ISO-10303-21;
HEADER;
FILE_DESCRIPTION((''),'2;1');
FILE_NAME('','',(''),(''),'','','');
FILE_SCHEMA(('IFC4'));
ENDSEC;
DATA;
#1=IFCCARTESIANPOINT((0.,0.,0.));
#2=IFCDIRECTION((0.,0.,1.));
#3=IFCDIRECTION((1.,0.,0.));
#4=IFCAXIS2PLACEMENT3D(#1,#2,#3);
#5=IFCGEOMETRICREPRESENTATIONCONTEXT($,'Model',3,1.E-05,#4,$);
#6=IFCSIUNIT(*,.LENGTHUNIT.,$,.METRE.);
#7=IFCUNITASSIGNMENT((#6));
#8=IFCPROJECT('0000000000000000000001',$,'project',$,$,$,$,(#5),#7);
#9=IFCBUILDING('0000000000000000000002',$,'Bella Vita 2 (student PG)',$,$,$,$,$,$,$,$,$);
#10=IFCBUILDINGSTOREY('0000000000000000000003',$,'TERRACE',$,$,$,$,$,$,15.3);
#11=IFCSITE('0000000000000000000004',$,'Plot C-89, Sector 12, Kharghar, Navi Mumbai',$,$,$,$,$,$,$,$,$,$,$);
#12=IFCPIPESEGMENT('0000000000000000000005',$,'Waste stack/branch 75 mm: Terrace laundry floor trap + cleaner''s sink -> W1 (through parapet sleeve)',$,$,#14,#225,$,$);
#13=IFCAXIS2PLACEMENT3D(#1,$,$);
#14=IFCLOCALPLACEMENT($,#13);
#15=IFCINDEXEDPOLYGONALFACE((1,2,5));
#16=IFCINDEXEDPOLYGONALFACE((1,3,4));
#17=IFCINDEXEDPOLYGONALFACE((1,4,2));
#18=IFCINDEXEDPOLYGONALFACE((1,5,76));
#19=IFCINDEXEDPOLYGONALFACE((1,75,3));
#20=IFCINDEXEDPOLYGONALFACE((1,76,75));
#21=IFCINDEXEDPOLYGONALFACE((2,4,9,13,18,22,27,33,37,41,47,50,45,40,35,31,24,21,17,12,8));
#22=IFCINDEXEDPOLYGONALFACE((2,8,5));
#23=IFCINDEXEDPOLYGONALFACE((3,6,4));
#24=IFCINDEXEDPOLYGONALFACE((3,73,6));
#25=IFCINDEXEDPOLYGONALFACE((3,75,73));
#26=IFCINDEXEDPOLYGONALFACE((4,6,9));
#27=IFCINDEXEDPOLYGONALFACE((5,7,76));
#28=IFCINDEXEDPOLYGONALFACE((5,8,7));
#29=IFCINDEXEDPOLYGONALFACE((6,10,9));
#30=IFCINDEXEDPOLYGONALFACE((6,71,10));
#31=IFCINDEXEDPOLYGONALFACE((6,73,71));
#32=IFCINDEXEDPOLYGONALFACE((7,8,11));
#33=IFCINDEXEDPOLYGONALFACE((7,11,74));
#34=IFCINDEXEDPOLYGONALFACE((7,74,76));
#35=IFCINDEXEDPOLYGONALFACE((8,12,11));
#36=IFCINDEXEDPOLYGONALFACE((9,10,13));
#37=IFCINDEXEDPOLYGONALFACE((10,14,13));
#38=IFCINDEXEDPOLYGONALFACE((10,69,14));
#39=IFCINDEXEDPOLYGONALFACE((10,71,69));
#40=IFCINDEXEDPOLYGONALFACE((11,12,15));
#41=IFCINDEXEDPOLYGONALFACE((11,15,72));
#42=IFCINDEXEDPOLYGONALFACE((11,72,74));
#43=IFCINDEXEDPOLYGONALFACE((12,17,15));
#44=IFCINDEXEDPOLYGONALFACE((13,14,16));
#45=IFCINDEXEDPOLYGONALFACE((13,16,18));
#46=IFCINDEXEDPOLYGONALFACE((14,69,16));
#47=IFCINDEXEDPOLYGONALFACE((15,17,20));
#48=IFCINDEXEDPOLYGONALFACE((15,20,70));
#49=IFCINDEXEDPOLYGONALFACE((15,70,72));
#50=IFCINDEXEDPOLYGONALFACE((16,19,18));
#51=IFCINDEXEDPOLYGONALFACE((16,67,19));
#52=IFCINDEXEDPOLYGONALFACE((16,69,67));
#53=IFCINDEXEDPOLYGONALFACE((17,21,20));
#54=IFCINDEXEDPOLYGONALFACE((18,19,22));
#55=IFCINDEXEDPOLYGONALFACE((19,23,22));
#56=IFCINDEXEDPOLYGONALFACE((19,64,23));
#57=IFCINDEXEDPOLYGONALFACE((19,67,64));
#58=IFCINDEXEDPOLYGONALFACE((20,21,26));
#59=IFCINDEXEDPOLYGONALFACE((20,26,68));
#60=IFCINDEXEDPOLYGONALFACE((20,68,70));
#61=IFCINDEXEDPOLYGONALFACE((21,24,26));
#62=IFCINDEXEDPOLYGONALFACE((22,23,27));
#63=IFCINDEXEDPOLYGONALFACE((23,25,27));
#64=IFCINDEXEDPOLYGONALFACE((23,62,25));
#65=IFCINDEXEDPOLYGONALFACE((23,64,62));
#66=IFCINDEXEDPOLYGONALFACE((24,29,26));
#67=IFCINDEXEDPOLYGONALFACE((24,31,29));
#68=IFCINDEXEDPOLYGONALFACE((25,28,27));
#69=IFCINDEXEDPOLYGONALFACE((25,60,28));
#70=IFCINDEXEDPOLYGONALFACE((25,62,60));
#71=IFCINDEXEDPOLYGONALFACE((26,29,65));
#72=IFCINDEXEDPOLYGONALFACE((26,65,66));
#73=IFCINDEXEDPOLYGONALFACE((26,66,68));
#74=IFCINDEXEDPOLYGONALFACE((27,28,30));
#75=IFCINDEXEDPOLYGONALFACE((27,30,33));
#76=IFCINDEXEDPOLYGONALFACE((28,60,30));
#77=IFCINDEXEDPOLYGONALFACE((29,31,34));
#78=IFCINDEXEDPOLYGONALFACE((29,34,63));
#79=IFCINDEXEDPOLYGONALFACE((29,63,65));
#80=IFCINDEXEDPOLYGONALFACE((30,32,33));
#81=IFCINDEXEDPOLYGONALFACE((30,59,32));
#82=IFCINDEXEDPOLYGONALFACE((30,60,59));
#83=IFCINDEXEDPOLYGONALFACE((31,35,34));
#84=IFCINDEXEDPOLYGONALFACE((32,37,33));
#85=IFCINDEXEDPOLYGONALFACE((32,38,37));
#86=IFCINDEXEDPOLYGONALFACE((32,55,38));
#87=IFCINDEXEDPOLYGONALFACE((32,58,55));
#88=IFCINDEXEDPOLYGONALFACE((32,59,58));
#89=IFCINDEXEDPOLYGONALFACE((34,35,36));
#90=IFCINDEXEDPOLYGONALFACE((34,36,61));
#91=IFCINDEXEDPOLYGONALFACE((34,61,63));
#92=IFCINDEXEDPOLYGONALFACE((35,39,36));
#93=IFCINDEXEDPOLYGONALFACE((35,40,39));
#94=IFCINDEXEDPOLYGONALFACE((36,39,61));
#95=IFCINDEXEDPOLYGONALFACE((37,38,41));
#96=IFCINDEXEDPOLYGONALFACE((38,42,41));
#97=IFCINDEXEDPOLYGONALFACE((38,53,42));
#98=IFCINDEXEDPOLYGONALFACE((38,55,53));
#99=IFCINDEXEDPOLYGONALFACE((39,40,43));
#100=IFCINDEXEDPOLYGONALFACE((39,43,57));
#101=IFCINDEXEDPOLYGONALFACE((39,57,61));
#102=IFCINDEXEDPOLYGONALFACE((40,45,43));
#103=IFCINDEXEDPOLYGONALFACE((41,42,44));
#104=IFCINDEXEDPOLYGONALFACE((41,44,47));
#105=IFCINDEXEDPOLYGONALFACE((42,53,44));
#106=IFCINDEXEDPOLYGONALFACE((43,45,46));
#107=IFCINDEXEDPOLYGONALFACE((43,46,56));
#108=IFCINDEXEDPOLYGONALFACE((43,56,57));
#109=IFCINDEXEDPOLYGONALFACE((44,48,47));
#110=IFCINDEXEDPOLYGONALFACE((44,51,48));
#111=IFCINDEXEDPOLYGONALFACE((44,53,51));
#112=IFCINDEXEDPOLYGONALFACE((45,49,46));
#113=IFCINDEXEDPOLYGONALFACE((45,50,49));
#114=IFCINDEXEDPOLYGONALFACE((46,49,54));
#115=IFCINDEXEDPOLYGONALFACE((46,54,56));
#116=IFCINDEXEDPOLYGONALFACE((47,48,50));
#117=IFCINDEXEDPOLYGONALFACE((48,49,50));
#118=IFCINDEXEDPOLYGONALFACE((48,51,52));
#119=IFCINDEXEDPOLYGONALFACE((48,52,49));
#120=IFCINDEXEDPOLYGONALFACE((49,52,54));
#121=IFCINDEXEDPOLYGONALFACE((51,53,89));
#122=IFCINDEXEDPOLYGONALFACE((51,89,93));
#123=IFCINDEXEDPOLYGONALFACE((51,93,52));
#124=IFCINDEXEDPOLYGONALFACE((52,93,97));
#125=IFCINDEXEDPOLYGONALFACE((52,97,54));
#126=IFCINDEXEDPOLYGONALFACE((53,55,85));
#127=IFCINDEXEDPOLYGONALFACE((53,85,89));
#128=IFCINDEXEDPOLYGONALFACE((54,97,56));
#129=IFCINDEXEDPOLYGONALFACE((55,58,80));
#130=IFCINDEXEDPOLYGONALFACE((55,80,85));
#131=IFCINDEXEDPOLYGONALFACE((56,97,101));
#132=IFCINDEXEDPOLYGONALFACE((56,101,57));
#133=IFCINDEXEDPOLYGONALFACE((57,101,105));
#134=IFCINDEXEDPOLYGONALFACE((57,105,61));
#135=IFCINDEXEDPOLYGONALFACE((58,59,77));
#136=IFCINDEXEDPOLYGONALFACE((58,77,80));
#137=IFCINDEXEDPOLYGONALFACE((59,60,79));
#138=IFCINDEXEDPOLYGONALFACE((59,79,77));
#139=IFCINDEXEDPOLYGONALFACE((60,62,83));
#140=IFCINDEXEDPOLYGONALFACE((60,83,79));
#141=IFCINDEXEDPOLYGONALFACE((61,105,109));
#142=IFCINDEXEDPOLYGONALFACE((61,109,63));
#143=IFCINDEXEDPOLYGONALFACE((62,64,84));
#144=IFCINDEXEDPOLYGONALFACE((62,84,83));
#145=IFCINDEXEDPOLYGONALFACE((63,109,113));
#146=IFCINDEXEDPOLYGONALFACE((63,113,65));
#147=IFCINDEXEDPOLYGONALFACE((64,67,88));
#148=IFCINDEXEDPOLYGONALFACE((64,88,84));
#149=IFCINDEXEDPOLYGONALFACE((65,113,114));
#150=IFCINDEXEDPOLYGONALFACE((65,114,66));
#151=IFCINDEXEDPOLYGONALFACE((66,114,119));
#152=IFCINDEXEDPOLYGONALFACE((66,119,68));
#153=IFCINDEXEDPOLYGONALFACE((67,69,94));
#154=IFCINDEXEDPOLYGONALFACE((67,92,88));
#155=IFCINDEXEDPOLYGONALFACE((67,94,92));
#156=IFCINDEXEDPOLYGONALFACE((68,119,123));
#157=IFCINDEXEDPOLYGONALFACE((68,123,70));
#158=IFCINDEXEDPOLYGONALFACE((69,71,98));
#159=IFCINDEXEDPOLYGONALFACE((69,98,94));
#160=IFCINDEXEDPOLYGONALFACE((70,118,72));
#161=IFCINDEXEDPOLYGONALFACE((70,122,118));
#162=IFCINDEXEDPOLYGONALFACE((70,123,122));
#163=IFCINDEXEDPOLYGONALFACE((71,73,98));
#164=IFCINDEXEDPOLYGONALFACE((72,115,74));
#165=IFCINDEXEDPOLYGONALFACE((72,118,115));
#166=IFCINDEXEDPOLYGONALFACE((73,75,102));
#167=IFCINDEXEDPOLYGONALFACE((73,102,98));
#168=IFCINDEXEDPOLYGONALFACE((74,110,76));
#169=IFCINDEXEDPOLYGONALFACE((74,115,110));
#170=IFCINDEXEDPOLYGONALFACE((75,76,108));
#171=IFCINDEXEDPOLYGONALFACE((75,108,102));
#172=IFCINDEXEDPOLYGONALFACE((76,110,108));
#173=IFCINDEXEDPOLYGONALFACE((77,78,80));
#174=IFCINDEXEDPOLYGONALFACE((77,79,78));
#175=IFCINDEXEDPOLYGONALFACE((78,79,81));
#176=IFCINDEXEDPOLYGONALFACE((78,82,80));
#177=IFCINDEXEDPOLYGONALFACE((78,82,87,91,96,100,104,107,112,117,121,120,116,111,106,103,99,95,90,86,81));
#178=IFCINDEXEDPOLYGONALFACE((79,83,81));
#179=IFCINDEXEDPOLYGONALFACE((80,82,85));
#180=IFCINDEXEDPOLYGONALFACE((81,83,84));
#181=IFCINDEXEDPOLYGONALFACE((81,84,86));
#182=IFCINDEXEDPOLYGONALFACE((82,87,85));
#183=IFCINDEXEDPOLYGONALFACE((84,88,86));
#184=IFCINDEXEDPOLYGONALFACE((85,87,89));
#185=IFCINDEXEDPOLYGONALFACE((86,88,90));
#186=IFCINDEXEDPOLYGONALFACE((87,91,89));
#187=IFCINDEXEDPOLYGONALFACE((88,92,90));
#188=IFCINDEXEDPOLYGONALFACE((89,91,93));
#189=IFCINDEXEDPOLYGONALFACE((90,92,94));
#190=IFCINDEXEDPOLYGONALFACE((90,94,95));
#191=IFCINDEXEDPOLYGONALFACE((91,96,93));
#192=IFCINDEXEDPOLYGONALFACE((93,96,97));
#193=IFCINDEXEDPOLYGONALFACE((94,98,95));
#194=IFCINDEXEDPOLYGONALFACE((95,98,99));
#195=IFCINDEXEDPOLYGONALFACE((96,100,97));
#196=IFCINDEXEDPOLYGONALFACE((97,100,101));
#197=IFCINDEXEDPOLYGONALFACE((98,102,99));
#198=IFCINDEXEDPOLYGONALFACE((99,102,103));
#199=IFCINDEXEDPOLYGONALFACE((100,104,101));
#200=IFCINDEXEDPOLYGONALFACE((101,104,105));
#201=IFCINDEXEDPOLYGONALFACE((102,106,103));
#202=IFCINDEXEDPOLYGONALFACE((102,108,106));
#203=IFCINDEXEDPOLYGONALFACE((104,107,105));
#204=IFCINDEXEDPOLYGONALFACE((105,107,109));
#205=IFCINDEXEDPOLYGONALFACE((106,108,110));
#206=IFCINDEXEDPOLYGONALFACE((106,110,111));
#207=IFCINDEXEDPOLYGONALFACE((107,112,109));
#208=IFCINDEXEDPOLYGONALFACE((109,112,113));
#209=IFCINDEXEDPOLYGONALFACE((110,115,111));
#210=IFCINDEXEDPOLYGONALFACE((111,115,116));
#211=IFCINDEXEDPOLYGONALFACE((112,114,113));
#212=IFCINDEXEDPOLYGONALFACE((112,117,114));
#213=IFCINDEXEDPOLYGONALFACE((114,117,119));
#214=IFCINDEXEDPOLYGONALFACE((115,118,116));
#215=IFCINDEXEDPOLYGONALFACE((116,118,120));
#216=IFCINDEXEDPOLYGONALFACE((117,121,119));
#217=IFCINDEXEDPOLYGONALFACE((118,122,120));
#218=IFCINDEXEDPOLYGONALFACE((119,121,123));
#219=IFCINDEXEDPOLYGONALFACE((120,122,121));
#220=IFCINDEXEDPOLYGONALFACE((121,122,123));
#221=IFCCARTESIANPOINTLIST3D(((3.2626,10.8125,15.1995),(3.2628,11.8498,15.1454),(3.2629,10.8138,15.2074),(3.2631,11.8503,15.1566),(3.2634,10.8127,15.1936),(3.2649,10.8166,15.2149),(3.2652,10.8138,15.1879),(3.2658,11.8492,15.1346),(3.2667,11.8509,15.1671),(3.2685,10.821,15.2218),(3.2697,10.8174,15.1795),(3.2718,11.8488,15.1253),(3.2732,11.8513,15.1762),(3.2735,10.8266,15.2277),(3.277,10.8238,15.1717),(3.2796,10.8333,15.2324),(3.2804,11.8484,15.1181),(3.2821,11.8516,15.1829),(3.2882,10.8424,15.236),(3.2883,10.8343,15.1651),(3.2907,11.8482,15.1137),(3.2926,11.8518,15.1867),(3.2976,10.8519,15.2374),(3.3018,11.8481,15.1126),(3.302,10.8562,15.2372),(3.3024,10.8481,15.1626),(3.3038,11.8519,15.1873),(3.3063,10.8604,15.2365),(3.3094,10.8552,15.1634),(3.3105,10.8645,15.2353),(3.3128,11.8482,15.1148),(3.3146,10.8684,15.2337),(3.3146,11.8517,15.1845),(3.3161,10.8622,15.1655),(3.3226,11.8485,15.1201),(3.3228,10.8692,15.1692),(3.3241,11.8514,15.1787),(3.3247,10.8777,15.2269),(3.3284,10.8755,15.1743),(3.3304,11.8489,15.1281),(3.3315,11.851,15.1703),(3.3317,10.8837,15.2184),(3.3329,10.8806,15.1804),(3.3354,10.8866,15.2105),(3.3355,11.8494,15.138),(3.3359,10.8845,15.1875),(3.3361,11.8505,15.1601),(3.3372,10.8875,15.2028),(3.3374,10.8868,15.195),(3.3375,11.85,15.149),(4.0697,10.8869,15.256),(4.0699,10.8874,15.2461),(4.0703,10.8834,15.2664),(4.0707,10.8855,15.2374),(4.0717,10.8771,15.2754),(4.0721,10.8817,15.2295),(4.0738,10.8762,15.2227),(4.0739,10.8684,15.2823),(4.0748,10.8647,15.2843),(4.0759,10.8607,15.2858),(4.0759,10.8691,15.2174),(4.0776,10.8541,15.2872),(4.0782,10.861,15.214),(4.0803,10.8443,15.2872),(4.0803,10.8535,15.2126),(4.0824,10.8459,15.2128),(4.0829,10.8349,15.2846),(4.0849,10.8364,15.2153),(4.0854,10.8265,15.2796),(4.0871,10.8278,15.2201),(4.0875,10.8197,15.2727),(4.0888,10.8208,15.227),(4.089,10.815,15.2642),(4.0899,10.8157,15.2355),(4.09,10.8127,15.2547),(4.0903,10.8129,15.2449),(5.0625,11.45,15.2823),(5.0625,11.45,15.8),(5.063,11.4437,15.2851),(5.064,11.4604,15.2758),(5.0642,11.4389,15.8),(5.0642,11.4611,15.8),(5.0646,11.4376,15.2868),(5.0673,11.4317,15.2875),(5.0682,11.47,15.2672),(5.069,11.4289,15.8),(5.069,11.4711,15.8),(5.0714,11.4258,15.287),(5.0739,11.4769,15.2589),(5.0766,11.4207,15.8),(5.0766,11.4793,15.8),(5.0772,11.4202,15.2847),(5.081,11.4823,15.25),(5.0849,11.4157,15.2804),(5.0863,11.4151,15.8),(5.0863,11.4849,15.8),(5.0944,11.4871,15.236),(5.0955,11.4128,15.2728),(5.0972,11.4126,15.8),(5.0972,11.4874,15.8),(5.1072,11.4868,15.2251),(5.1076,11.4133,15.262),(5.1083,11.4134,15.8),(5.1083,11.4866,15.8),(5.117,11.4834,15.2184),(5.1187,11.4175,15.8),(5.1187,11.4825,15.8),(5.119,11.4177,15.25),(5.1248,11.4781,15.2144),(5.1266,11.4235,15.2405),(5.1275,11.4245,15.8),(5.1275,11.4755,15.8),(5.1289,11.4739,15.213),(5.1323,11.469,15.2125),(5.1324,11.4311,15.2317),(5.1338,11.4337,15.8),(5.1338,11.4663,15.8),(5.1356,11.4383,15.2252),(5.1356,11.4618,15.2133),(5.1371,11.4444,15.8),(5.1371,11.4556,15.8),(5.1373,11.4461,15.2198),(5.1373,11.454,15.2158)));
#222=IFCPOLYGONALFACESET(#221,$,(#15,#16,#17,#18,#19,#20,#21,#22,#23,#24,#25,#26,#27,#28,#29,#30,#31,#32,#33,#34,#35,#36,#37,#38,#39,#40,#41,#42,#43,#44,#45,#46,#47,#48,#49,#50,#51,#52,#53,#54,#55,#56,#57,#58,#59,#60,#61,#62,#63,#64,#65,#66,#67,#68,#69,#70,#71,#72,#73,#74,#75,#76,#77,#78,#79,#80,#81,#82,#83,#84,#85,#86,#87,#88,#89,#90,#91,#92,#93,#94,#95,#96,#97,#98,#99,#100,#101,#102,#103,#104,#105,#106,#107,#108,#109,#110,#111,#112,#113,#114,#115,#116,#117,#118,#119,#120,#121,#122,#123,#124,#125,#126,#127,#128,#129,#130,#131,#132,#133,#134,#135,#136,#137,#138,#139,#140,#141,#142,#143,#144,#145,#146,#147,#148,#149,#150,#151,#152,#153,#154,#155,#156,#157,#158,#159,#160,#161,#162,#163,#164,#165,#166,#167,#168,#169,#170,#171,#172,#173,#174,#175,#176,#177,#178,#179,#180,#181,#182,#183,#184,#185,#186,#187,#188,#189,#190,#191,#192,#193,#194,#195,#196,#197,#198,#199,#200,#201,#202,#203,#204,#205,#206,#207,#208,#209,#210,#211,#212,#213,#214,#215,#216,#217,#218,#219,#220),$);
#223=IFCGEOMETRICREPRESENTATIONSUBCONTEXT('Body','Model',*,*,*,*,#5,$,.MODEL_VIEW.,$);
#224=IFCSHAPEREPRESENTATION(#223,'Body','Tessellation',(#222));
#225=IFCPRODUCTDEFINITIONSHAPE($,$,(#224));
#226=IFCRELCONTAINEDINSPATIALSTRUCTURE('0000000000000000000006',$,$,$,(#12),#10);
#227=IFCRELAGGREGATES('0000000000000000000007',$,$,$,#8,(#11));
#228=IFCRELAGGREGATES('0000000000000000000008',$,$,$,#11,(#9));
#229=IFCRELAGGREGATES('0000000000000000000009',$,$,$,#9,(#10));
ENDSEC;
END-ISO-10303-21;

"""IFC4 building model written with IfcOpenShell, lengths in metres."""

from ifc_helpers import new_model, entity, si_unit, origin, origin_with_axes, place, context, subcontext, project, spatial, element, save


model = new_model("IFC4")

# Units and contexts
model_context = context("Model", 3, precision=1e-05, world=origin_with_axes())
body_context = subcontext(model_context, "Body", "Model", "MODEL_VIEW")
ifc_project = project(units=[si_unit("LENGTHUNIT", "METRE")], contexts=[model_context])

# Site, building, storey
site = spatial("IfcSite", under=ifc_project, Name="Plot C-89, Sector 12, Kharghar, Navi Mumbai")
building = spatial("IfcBuilding", under=site, Name="Bella Vita 2 (student PG)")
storey = spatial("IfcBuildingStorey", under=building, Name="TERRACE", Elevation=15.3)

# Pipe segment
pipe_segment_1_placement = place(None, origin())
element("IfcPipeSegment", 1, at=pipe_segment_1_placement, inside=storey, Name="Waste stack/branch 75 mm: Terrace laundry floor trap + cleaner's sink -> W1 (through parapet sleeve)", context=body_context, shape_type="AdvancedSweptSolid", body=[
    entity("IfcSweptDiskSolid", entity("IfcPolyline", [entity("IfcCartesianPoint", [5.1, 11.45, 15.8]), entity("IfcCartesianPoint", [5.1, 11.45, 15.25]), entity("IfcCartesianPoint", [4.08, 10.85, 15.25]), entity("IfcCartesianPoint", [3.3, 10.85, 15.2]), entity("IfcCartesianPoint", [3.3, 11.85, 15.15])]), 0.0375),
])

save(model, "model.ifc")
